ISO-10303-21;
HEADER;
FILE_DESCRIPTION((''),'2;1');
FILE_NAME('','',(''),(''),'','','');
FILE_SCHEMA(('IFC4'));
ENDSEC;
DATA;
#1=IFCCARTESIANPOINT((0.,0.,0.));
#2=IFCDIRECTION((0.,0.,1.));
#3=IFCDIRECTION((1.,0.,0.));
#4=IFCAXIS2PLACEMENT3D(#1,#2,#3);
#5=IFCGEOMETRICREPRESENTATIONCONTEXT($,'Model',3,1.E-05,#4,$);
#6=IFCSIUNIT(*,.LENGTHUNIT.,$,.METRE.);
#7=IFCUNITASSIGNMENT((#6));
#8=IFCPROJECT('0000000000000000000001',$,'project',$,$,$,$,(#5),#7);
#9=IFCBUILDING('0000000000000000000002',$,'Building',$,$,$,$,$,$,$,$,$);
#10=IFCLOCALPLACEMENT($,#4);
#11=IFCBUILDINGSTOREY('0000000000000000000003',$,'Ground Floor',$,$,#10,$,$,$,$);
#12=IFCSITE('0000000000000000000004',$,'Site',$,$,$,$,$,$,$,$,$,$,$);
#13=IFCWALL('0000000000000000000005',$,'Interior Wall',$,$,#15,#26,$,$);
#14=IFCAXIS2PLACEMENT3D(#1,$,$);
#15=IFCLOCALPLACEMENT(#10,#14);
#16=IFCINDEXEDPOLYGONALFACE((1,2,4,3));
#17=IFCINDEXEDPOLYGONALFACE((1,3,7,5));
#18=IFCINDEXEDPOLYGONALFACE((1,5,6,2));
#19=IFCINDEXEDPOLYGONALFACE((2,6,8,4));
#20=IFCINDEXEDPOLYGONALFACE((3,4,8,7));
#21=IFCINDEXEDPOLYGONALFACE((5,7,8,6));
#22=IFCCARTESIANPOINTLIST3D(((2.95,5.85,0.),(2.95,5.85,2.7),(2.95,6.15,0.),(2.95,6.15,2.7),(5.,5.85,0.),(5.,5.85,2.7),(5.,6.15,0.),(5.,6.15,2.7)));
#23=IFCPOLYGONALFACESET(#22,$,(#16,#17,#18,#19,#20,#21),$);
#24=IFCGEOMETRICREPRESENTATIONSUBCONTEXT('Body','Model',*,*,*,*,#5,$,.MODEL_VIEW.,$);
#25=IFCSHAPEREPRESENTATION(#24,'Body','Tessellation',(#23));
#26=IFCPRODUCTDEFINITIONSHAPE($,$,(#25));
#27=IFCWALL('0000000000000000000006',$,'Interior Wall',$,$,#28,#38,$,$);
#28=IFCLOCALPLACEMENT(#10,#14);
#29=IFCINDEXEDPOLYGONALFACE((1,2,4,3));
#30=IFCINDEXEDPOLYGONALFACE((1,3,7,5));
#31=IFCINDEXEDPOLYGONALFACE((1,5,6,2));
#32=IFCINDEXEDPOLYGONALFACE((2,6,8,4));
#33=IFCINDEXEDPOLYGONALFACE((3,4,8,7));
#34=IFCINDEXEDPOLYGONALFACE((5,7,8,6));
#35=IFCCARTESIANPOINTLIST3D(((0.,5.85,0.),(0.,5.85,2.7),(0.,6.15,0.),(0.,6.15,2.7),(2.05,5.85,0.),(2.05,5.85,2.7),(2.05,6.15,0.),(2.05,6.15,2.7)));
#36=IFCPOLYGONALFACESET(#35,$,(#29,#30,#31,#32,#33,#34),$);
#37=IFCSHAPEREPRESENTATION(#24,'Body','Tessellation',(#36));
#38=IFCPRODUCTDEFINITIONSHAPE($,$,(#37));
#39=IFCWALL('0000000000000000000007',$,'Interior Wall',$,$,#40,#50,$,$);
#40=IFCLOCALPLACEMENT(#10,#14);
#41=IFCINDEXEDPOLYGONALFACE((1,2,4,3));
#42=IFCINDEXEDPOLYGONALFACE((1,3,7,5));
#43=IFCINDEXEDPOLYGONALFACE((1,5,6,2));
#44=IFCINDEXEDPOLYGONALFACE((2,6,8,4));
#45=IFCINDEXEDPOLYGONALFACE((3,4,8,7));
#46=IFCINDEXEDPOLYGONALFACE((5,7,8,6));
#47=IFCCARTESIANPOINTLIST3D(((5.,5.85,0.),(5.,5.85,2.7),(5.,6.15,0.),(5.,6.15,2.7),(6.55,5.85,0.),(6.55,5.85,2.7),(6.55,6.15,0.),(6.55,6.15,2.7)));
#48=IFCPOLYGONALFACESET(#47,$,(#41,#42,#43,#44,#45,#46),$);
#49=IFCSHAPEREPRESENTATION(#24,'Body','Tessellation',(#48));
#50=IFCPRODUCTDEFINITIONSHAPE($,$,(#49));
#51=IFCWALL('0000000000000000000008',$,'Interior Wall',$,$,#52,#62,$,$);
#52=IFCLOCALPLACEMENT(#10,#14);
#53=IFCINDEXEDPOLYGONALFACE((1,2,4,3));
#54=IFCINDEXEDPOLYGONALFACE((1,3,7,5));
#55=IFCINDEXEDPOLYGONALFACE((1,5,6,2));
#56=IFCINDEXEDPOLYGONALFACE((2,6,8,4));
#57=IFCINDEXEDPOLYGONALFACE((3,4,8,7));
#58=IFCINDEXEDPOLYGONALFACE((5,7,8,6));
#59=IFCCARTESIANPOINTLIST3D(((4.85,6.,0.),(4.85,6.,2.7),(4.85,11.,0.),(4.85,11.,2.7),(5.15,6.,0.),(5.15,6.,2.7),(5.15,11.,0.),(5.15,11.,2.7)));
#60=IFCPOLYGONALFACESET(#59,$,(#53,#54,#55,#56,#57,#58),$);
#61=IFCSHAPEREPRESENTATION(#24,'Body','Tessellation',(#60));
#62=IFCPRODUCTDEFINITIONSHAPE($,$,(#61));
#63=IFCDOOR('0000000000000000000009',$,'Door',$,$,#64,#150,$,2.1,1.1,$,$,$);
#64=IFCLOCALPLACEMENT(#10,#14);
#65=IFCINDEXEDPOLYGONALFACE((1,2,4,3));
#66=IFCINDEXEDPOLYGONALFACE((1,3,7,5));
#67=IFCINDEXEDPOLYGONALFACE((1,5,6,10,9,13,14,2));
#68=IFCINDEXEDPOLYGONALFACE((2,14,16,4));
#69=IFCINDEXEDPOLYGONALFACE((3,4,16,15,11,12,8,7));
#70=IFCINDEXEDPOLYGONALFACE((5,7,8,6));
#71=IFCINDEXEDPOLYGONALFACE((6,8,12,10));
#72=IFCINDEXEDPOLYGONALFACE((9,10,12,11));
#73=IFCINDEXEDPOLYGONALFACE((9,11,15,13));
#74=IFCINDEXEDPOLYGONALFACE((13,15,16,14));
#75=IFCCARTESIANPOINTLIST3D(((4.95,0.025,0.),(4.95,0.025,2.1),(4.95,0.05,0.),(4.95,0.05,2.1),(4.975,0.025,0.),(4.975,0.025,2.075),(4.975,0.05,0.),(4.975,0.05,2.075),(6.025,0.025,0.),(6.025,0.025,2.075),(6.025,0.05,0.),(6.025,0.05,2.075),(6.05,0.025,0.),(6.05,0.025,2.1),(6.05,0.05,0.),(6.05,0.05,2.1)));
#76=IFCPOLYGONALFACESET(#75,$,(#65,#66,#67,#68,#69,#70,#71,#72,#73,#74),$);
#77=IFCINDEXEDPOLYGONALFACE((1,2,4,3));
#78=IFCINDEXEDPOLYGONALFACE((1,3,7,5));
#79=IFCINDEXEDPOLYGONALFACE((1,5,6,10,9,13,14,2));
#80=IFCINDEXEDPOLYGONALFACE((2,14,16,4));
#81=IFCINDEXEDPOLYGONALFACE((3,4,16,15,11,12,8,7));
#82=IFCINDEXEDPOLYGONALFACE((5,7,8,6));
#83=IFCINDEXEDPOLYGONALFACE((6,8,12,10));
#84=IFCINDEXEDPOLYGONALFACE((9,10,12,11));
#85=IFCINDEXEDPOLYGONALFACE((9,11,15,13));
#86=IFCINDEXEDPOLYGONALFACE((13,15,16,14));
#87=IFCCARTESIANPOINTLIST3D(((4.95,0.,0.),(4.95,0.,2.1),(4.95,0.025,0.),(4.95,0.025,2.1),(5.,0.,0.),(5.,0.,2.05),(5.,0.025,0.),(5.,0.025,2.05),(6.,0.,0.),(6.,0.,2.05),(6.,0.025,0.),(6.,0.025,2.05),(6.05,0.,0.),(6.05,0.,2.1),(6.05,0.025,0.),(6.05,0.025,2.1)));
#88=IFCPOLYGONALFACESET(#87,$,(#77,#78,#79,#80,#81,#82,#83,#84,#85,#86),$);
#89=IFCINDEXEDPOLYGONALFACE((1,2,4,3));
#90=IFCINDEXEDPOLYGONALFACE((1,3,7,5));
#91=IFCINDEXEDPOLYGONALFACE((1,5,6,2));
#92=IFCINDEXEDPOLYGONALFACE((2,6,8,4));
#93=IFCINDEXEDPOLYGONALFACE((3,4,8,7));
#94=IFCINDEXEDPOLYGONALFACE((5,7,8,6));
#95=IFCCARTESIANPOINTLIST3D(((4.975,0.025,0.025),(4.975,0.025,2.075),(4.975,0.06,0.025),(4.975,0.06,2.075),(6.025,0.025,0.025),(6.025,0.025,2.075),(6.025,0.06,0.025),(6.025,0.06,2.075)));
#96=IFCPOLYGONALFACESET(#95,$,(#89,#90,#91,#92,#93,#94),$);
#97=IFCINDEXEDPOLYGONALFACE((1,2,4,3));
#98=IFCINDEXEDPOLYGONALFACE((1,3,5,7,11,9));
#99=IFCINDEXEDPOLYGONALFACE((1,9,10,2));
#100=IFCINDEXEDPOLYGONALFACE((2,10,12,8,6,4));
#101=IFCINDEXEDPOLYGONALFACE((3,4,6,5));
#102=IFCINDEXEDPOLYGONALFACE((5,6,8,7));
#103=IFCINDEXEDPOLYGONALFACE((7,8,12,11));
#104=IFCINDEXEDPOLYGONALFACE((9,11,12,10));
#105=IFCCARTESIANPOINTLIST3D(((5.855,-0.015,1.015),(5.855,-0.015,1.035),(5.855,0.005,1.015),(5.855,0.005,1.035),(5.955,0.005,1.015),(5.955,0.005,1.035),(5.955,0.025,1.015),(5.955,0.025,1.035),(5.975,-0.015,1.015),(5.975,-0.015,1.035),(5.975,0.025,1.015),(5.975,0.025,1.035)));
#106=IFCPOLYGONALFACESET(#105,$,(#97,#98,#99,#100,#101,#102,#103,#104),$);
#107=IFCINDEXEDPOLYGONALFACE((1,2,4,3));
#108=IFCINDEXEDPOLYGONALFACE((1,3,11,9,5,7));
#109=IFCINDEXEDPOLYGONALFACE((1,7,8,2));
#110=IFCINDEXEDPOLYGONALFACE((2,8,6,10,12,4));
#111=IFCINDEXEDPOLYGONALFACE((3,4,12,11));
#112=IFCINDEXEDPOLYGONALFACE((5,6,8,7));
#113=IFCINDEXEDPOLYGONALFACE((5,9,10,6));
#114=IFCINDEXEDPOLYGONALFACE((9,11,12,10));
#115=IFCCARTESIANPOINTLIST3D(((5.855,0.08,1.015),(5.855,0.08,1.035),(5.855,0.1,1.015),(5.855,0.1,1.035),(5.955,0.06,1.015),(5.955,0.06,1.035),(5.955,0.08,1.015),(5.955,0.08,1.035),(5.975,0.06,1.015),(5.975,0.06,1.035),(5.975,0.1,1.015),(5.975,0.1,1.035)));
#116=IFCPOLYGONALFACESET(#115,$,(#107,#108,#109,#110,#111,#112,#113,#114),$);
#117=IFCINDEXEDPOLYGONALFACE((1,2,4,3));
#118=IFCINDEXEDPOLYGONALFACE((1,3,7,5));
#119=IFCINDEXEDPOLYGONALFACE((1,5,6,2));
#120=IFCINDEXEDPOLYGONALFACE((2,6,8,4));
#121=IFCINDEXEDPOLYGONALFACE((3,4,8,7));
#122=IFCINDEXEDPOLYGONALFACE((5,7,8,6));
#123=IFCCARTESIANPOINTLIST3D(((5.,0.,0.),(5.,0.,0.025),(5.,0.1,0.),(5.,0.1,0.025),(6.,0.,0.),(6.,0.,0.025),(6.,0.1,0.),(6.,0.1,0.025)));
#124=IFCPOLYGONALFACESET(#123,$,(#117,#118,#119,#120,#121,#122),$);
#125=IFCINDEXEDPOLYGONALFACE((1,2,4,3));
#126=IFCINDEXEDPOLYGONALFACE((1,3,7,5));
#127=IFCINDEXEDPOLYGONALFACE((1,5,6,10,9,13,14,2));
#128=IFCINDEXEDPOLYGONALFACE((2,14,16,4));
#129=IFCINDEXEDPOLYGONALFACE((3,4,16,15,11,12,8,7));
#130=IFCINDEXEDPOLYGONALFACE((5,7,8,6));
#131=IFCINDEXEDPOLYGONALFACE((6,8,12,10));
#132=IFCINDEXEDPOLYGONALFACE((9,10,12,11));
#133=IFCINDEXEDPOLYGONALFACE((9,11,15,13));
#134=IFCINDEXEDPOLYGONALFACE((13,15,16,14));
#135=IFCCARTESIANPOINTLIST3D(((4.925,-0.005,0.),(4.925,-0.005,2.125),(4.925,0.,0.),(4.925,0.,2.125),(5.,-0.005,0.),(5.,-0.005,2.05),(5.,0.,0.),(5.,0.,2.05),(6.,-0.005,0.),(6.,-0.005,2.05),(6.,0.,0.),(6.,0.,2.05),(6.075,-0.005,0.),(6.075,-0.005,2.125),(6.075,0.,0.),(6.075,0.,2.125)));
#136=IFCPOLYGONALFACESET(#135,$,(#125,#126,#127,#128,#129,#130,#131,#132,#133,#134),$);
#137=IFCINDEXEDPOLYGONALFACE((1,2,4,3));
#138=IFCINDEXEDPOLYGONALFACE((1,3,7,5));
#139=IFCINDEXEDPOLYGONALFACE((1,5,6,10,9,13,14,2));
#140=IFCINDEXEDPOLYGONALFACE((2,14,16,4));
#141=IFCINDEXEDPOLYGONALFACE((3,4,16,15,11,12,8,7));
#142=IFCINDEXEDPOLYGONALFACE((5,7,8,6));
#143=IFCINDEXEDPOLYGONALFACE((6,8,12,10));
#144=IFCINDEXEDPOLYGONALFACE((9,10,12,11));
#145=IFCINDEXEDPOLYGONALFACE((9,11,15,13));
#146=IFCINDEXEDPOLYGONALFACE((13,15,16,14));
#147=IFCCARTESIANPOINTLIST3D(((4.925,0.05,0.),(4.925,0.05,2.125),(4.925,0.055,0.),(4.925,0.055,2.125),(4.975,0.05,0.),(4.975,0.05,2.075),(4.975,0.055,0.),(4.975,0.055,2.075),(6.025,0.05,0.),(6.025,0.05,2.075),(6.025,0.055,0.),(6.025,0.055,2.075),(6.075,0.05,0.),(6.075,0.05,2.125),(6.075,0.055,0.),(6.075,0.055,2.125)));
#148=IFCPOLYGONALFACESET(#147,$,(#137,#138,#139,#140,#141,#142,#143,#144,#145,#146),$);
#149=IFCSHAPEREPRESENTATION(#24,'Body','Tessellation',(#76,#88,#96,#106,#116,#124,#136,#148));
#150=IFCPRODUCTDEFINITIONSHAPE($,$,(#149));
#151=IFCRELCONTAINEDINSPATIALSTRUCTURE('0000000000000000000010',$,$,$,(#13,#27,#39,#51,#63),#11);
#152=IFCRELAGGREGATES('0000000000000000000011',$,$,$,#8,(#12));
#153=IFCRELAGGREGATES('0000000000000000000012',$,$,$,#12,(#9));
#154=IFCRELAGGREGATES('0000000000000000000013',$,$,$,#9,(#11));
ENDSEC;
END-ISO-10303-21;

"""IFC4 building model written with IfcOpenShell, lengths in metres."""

from ifc_helpers import new_model, si_unit, frame, origin_with_axes, place, context, subcontext, project, spatial, line, indexed_curve, outline, extrude, element, save


model = new_model("IFC4")

# Units and contexts
model_context = context("Model", 3, precision=1e-05, world=origin_with_axes())
body_context = subcontext(model_context, "Body", "Model", "MODEL_VIEW")
ifc_project = project(units=[si_unit("LENGTHUNIT", "METRE")], contexts=[model_context])

# Site, building, storey
site = spatial("IfcSite", under=ifc_project, Name="Site")
building = spatial("IfcBuilding", under=site, Name="Building")
storey_placement = place(None, origin_with_axes())
storey = spatial("IfcBuildingStorey", under=building, at=storey_placement, Name="Ground Floor")

# Walls
for number, where, z_axis, x_axis, name in (
    (1, (5.0, 6.0, 0.0), (0.0, 0.0, 1.0), (-1.0, 0.0, 0.0), "Interior Wall"),
    (2, (2.05, 6.0, 0.0), (0.0, 0.0, 1.0), (-1.0, 0.0, 0.0), "Interior Wall"),
):
    element("IfcWall", number, at=place(storey_placement, frame(where, z_axis=z_axis, x_axis=x_axis)), inside=storey, Name=name, context=body_context, shape_type="SweptSolid", body=[
        extrude(outline(indexed_curve([(0.0, 0.0), (0.0, 0.3), (2.05, 0.3), (2.05, 0.0), (0.0, 0.0)], self_intersect=False)), frame((0.0, -0.15, 0.0), z_axis=(0.0, 0.0, 1.0), x_axis=(1.0, 0.0, 0.0)), (0.0, 0.0, 1.0), 2.7),
    ])
wall_1_placement = place(storey_placement, frame((6.55, 6.0, 0.0), z_axis=(0.0, 0.0, 1.0), x_axis=(-1.0, 0.0, 0.0)))
element("IfcWall", 3, at=wall_1_placement, inside=storey, Name="Interior Wall", context=body_context, shape_type="SweptSolid", body=[
    extrude(outline(indexed_curve([(0.0, 0.0), (0.0, 0.3), (1.55, 0.3), (1.55, 0.0), (0.0, 0.0)], self_intersect=False)), frame((0.0, -0.15, 0.0), z_axis=(0.0, 0.0, 1.0), x_axis=(1.0, 0.0, 0.0)), (0.0, 0.0, 1.0), 2.7),
])
wall_2_placement = place(storey_placement, frame((5.0, 6.0, 0.0), z_axis=(0.0, 0.0, 1.0), x_axis=(0.0, 1.0, 0.0)))
element("IfcWall", 4, at=wall_2_placement, inside=storey, Name="Interior Wall", context=body_context, shape_type="SweptSolid", body=[
    extrude(outline(indexed_curve([(0.0, 0.0), (0.0, 0.3), (5.0, 0.3), (5.0, 0.0), (0.0, 0.0)], self_intersect=False)), frame((0.0, -0.15, 0.0), z_axis=(0.0, 0.0, 1.0), x_axis=(1.0, 0.0, 0.0)), (0.0, 0.0, 1.0), 2.7),
])

# Door
door_1_placement = place(storey_placement, frame((4.95, 0.0, 0.0), z_axis=(0.0, 0.0, 1.0), x_axis=(1.0, 0.0, 0.0)))
element("IfcDoor", 5, at=door_1_placement, inside=storey, Name="Door", OverallHeight=2.1, OverallWidth=1.1, context=body_context, shape_type="SweptSolid", body=[
    extrude(outline(indexed_curve([(0.0, 0.0), (0.0, 2.1), (1.1, 2.1), (1.1, 0.0), (1.075, 0.0), (1.075, 2.075), (0.025, 2.075), (0.025, 0.0)], segments=[line(1, 2, 3, 4, 5, 6, 7, 8, 1)])), frame((0.0, 0.025, 0.0), z_axis=(0.0, -1.0, 0.0), x_axis=(1.0, 0.0, 0.0)), (0.0, 0.0, -1.0), 0.025),
    extrude(outline(indexed_curve([(0.0, 0.0), (0.0, 2.1), (1.1, 2.1), (1.1, 0.0), (1.05, 0.0), (1.05, 2.05), (0.05, 2.05), (0.05, 0.0)], segments=[line(1, 2, 3, 4, 5, 6, 7, 8, 1)])), frame((0.0, 0.0, 0.0), z_axis=(0.0, -1.0, 0.0), x_axis=(1.0, 0.0, 0.0)), (0.0, 0.0, -1.0), 0.025),
    extrude(outline(indexed_curve([(0.0, 0.0), (1.05, 0.0), (1.05, 0.035), (0.0, 0.035)], segments=[line(1, 2, 3, 4, 1)])), frame((0.025, 0.025, 0.025), z_axis=(0.0, 0.0, 1.0), x_axis=(1.0, 0.0, 0.0)), (0.0, 0.0, 1.0), 2.05),
    extrude(outline(indexed_curve([(0.0, 0.0), (0.0, -0.04), (-0.12, -0.04), (-0.12, -0.02), (-0.02, -0.02), (-0.02, 0.0)], segments=[line(1, 2, 3, 4, 5, 6, 1)])), frame((1.025, 0.025, 1.015), z_axis=(0.0, 0.0, 1.0), x_axis=(1.0, 0.0, 0.0)), (0.0, 0.0, 1.0), 0.02),
    extrude(outline(indexed_curve([(0.0, 0.0), (0.0, 0.04), (-0.12, 0.04), (-0.12, 0.02), (-0.02, 0.02), (-0.02, 0.0)], segments=[line(1, 2, 3, 4, 5, 6, 1)])), frame((1.025, 0.06, 1.015), z_axis=(0.0, 0.0, 1.0), x_axis=(1.0, 0.0, 0.0)), (0.0, 0.0, 1.0), 0.02),
    extrude(outline(indexed_curve([(0.0, 0.0), (1.0, 0.0), (1.0, 0.1), (0.0, 0.1)], segments=[line(1, 2, 3, 4, 1)])), frame((0.05, 0.0, 0.0), z_axis=(0.0, 0.0, 1.0), x_axis=(1.0, 0.0, 0.0)), (0.0, 0.0, 1.0), 0.025),
    extrude(outline(indexed_curve([(0.0, 0.0), (0.0, 2.125), (1.15, 2.125), (1.15, 0.0), (1.075, 0.0), (1.075, 2.05), (0.075, 2.05), (0.075, 0.0)], segments=[line(1, 2, 3, 4, 5, 6, 7, 8, 1)])), frame((-0.025, -0.005, 0.0), z_axis=(0.0, -1.0, 0.0), x_axis=(1.0, 0.0, 0.0)), (0.0, 0.0, -1.0), 0.005),
    extrude(outline(indexed_curve([(0.0, 0.0), (0.0, 2.125), (1.15, 2.125), (1.15, 0.0), (1.1, 0.0), (1.1, 2.075), (0.05, 2.075), (0.05, 0.0)], segments=[line(1, 2, 3, 4, 5, 6, 7, 8, 1)])), frame((-0.025, 0.05, 0.0), z_axis=(0.0, -1.0, 0.0), x_axis=(1.0, 0.0, 0.0)), (0.0, 0.0, -1.0), 0.005),
])

save(model, "model.ifc")
